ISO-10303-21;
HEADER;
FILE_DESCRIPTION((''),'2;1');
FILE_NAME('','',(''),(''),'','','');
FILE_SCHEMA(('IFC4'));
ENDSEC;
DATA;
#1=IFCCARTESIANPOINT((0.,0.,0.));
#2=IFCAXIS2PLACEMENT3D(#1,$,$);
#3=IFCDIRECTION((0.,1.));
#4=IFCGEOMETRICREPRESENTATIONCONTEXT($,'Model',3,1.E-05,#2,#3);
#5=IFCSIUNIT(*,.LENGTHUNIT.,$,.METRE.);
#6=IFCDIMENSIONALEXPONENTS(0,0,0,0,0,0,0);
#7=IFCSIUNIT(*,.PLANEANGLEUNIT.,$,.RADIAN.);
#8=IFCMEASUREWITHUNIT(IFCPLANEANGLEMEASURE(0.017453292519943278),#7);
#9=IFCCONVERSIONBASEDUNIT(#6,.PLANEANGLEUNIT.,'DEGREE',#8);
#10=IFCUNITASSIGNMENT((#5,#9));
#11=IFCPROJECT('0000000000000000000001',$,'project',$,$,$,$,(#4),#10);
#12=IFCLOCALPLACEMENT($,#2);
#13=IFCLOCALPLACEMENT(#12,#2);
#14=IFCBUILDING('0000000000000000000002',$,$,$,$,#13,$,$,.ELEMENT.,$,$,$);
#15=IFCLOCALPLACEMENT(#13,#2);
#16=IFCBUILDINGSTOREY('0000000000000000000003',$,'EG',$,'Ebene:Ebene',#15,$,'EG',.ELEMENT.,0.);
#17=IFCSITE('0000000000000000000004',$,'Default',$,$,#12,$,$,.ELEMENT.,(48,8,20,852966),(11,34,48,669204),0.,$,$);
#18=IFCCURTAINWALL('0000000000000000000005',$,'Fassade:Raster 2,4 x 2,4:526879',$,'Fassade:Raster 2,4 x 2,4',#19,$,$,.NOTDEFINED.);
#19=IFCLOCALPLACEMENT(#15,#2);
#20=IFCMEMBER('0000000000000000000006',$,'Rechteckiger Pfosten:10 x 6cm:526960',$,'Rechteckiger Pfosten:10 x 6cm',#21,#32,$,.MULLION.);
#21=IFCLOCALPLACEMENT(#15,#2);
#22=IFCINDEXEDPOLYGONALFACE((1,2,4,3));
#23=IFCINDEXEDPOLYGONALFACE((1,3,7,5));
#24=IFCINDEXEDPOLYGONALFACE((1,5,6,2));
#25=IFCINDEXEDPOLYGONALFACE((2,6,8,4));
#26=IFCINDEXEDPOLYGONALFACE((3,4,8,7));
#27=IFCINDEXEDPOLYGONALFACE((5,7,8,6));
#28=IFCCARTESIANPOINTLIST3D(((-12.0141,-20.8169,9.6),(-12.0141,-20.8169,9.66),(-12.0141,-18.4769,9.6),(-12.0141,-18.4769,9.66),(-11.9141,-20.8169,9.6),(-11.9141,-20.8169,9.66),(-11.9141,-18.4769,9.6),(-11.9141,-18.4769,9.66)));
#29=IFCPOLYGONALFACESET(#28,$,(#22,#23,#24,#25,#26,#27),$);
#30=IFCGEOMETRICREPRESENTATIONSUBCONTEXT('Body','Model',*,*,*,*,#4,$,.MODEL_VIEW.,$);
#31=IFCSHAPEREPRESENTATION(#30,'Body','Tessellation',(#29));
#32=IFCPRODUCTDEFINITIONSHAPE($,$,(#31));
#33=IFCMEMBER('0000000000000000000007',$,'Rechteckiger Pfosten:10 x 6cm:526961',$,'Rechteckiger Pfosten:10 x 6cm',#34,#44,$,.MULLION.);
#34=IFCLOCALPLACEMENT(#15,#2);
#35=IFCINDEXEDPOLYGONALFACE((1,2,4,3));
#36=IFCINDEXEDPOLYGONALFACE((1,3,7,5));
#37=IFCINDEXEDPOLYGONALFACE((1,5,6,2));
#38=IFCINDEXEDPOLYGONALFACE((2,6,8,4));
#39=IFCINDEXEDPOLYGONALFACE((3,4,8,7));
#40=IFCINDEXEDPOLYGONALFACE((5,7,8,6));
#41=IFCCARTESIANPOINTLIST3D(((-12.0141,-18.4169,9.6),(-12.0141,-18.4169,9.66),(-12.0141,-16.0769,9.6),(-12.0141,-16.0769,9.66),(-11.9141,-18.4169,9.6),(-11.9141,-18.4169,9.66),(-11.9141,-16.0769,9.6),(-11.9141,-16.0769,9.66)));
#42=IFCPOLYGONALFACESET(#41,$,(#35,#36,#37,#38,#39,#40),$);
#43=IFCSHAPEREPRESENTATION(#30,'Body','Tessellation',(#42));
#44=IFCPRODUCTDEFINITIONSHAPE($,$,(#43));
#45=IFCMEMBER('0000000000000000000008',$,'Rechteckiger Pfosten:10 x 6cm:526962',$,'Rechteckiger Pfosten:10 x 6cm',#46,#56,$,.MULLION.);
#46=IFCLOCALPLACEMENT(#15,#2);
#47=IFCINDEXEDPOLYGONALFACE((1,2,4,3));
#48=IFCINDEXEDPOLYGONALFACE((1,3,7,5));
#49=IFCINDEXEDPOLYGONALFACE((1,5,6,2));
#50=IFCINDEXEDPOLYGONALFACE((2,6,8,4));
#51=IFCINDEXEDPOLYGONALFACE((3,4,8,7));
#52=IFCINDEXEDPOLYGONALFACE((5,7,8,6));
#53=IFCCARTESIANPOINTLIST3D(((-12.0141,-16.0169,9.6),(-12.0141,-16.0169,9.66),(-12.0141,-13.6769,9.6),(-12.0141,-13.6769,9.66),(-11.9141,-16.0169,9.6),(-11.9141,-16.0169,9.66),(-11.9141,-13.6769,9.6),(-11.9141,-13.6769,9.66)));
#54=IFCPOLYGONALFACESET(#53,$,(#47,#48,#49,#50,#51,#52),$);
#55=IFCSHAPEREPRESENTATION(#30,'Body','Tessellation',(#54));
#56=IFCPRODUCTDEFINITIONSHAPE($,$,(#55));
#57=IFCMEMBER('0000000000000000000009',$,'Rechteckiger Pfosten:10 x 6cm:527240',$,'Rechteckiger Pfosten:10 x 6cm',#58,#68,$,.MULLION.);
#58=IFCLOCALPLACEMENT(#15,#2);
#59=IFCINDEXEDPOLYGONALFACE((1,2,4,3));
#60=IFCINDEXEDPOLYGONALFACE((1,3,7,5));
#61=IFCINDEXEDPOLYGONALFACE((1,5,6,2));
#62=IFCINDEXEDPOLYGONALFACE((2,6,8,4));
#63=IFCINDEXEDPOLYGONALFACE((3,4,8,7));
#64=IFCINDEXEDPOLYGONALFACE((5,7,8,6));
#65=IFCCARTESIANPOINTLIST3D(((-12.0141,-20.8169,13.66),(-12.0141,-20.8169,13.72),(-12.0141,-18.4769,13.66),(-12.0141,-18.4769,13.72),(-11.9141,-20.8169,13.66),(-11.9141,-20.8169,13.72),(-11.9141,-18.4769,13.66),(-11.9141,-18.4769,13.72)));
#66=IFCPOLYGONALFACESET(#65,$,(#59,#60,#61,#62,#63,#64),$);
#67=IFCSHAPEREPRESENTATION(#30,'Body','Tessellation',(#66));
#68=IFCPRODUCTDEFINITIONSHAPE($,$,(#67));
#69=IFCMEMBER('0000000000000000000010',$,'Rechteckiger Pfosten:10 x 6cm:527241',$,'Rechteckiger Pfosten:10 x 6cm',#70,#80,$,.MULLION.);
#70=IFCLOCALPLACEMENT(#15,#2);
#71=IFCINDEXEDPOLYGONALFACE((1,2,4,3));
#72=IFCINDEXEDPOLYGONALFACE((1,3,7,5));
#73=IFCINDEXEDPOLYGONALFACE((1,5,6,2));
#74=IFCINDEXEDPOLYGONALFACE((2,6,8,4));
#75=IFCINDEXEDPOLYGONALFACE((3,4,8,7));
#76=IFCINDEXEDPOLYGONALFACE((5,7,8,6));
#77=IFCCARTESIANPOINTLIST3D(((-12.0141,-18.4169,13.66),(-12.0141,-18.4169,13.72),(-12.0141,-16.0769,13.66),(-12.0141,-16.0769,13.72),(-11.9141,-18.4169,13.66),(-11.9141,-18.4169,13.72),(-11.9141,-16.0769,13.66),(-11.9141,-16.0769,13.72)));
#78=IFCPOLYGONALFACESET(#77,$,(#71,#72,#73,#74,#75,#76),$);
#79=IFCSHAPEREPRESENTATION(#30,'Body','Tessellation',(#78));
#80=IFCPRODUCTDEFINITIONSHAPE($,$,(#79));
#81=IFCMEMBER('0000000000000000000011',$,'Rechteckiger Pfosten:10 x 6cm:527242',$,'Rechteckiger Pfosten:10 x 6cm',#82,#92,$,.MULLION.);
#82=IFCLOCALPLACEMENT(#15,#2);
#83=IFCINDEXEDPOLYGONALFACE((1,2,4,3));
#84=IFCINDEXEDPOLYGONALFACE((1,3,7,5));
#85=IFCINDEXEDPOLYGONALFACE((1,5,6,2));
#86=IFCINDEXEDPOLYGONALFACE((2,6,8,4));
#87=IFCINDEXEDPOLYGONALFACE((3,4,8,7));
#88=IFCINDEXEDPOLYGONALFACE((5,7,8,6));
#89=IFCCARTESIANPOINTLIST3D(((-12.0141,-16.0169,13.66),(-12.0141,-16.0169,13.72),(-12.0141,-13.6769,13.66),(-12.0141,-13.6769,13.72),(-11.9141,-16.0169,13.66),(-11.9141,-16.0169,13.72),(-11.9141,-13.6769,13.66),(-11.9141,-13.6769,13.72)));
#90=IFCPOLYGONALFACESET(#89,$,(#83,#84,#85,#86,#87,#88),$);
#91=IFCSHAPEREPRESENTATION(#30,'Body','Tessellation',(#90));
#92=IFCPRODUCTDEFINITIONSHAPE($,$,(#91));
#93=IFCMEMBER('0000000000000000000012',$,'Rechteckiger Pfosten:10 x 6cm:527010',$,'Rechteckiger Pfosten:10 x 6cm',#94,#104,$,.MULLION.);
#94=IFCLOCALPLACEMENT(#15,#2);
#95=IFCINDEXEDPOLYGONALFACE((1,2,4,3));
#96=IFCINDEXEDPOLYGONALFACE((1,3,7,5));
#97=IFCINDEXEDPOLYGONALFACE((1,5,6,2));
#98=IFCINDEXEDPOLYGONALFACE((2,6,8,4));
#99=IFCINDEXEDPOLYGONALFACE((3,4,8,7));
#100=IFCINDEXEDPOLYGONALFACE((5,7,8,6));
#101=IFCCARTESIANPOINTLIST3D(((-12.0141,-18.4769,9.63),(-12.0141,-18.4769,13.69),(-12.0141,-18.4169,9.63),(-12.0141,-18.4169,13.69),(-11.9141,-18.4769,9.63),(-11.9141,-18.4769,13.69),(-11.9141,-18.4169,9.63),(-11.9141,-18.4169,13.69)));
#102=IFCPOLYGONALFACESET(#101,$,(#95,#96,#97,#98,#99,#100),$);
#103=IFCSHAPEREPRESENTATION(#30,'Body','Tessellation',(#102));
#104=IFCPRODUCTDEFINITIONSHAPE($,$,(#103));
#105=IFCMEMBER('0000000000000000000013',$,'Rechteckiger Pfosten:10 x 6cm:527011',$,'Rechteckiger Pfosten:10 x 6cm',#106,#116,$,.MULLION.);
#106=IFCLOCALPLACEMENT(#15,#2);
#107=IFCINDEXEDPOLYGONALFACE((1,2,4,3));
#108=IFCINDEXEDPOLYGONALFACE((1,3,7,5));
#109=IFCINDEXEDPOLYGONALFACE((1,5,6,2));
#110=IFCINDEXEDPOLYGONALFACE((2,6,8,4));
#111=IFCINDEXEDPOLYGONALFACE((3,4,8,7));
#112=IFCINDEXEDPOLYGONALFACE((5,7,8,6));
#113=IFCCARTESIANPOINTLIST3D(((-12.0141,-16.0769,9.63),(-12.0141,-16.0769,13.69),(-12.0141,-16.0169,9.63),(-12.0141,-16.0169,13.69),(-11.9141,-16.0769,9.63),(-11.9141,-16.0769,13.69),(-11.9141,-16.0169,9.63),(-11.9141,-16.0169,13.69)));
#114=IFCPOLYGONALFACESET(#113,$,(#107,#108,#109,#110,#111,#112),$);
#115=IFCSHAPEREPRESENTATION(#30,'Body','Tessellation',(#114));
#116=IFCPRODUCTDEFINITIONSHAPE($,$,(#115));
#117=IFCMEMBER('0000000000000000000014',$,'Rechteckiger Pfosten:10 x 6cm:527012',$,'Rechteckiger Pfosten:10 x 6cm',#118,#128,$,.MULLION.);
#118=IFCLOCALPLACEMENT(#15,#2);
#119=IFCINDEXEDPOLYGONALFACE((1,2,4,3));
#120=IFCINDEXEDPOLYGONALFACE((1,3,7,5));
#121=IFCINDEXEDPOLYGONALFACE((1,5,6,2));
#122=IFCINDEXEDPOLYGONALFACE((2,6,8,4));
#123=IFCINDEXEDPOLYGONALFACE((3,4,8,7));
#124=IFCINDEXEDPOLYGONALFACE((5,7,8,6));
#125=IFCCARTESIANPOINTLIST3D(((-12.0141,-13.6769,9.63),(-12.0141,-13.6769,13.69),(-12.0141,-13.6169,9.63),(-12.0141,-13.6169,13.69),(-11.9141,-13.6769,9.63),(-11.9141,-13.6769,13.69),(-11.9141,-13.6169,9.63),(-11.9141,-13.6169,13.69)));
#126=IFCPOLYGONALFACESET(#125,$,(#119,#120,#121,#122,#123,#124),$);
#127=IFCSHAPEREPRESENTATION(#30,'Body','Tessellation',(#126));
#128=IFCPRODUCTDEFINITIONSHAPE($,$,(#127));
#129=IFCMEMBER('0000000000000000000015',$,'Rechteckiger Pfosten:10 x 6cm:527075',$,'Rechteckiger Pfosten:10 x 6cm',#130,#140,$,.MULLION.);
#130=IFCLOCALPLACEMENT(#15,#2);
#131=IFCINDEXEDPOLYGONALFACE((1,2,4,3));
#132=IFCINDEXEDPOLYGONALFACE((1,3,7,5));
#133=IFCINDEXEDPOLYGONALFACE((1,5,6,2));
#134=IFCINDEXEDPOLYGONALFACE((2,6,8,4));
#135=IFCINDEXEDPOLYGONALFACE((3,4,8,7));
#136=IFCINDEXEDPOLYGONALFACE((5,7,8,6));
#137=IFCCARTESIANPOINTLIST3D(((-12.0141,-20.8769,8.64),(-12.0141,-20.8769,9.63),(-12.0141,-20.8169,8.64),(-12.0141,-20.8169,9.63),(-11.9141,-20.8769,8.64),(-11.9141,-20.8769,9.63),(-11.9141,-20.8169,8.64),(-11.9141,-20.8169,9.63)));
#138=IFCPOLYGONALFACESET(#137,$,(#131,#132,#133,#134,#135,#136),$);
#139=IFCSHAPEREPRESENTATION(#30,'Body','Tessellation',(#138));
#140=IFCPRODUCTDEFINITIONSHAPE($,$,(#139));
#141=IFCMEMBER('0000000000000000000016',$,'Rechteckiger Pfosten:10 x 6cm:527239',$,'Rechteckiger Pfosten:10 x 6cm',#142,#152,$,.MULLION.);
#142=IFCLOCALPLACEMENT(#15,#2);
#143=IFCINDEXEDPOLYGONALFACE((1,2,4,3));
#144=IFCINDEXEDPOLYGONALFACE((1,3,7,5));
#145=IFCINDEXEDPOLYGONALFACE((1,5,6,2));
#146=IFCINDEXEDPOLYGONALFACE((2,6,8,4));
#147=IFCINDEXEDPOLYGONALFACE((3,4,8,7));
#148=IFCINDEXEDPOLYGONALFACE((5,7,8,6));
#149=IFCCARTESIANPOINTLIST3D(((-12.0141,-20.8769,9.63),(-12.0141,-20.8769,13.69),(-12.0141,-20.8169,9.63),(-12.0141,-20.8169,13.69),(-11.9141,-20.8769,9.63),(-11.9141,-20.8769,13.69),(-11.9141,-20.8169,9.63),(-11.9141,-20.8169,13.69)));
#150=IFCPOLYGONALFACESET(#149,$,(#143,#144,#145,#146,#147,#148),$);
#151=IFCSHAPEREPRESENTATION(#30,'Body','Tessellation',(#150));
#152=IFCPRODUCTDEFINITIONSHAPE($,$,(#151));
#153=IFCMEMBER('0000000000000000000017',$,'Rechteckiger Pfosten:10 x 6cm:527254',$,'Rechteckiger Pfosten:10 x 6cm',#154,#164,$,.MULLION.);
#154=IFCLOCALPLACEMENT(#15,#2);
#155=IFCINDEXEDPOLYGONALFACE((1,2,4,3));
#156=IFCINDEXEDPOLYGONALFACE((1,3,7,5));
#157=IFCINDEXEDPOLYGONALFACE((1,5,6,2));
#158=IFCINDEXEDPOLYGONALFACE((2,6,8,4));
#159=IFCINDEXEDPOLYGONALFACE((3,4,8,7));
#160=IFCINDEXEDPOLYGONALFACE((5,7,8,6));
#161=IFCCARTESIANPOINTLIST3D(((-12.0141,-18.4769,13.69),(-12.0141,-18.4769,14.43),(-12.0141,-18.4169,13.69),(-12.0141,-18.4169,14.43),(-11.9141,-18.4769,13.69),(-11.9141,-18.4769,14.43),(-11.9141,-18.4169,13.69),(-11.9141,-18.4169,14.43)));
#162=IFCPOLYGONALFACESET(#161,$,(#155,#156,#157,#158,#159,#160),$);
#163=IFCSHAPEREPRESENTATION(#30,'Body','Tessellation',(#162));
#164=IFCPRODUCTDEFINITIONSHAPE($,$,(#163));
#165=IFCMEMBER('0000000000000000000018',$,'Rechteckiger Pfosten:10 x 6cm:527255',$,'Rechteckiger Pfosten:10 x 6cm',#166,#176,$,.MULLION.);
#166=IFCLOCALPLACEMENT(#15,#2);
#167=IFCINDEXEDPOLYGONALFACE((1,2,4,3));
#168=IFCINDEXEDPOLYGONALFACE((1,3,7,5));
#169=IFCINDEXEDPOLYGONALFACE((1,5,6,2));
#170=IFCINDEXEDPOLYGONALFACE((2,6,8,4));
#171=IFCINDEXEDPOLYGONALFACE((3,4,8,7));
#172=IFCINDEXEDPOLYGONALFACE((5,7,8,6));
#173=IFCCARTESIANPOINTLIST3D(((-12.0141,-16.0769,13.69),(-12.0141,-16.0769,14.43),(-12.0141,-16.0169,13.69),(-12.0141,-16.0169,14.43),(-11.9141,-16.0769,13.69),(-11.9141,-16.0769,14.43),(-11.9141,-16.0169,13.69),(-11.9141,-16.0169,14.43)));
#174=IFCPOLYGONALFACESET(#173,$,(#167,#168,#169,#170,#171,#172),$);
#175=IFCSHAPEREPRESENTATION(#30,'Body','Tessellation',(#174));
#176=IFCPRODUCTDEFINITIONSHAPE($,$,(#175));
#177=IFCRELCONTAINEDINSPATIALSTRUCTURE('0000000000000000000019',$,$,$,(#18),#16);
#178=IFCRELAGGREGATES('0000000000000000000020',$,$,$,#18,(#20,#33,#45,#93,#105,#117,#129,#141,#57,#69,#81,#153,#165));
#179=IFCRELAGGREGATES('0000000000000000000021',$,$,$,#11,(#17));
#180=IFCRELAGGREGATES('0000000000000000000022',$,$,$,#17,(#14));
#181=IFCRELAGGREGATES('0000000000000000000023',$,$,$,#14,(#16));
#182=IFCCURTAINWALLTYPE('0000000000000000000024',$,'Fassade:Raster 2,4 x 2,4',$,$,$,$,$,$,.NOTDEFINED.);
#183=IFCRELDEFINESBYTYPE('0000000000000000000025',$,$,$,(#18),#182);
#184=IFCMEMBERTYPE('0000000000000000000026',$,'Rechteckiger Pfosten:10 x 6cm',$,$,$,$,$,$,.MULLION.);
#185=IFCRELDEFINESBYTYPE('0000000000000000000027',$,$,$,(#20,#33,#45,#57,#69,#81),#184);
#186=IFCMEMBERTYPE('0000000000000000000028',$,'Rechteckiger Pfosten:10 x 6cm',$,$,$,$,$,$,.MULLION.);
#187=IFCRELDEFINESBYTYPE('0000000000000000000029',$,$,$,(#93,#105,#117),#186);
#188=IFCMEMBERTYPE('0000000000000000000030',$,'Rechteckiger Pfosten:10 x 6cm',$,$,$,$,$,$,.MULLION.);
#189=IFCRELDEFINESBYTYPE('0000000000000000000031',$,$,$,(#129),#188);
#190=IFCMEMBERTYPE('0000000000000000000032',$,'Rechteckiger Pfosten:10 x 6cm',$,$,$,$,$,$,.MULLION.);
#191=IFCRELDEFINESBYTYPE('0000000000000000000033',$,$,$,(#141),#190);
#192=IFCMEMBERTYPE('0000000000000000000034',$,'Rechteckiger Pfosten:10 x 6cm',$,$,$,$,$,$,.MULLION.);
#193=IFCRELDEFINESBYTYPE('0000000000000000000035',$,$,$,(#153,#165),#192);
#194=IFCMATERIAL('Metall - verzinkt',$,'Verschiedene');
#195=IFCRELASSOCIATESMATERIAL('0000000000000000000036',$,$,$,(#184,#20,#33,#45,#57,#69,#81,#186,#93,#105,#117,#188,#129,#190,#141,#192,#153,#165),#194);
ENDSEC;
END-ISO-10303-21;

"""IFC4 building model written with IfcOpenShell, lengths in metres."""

from ifc_helpers import new_model, entity, si_unit, converted_unit, direction, frame, origin, place, context, subcontext, project, spatial, indexed_curve, outline, extrude, source, transform, mapped, material, type_object, type_shapes, element, aggregate, save


model = new_model("IFC4")

# Units and contexts
model_context = context("Model", 3, precision=1e-05, world=origin(), true_north=direction((0.0, 1.0)))
body_context = subcontext(model_context, "Body", "Model", "MODEL_VIEW")
ifc_project = project(units=[si_unit("LENGTHUNIT", "METRE"), converted_unit("PLANEANGLEUNIT", "DEGREE", entity("IfcPlaneAngleMeasure", 0.017453292519943278), si_unit("PLANEANGLEUNIT", "RADIAN"), dimensions=[0, 0, 0, 0, 0, 0, 0])], contexts=[model_context])

# Site, building, storey
site_placement = place(None, origin())
site = spatial("IfcSite", under=ifc_project, at=site_placement, Name="Default", CompositionType="ELEMENT", RefLatitude=(48, 8, 20, 852966), RefLongitude=(11, 34, 48, 669204), RefElevation=0.0)
building_placement = place(site_placement, origin())
building = spatial("IfcBuilding", under=site, at=building_placement, CompositionType="ELEMENT")
storey_placement = place(building_placement, origin())
storey = spatial("IfcBuildingStorey", under=building, at=storey_placement, Name="EG", ObjectType="Ebene:Ebene", LongName="EG", CompositionType="ELEMENT", Elevation=0.0)

# Curtain wall, members
curtain_wall_type = type_object("IfcCurtainWallType", Name="Fassade:Raster 2,4 x 2,4", PredefinedType="NOTDEFINED")
curtain_wall_placement = place(storey_placement, origin())
curtain_wall = element("IfcCurtainWall", 1, at=curtain_wall_placement, inside=storey, type_object=curtain_wall_type, Name="Fassade:Raster 2,4 x 2,4:526879", ObjectType="Fassade:Raster 2,4 x 2,4", PredefinedType="NOTDEFINED")
ifc_material_1 = material(Name="Metall - verzinkt", Category="Verschiedene")
member_type_1 = type_object("IfcMemberType", Name="Rechteckiger Pfosten:10 x 6cm", PredefinedType="MULLION", material=ifc_material_1)
shared_shape_1 = source(origin(), body_context, "Body", "SweptSolid", [
    extrude(outline(indexed_curve([(-0.03, -0.05), (0.03, -0.05), (0.03, 0.05), (-0.03, 0.05), (-0.03, -0.05)], self_intersect=False)), frame((0.0, 0.0, -2.34), z_axis=(0.0, 0.0, 1.0), x_axis=(-1.0, 0.0, 0.0)), (0.0, 0.0, 1.0), 2.34),
])
type_shapes(member_type_1, [shared_shape_1])
member_1_placement = place(curtain_wall_placement, frame((-11.9641, -18.4769, 9.63), z_axis=(0.0, 1.0, 0.0), x_axis=(0.0, 0.0, 1.0)))
member_1 = element("IfcMember", 2, at=member_1_placement, type_object=member_type_1, material=ifc_material_1, Name="Rechteckiger Pfosten:10 x 6cm:526960", ObjectType="Rechteckiger Pfosten:10 x 6cm", PredefinedType="MULLION", context=body_context, shape_type="MappedRepresentation", body=[
    mapped(shared_shape_1, transform((0.0, 0.0, 0.0), scale=1.0)),
])
member_2_placement = place(curtain_wall_placement, frame((-11.9641, -16.0769, 9.63), z_axis=(0.0, 1.0, 0.0), x_axis=(0.0, 0.0, 1.0)))
member_2 = element("IfcMember", 3, at=member_2_placement, type_object=member_type_1, material=ifc_material_1, Name="Rechteckiger Pfosten:10 x 6cm:526961", ObjectType="Rechteckiger Pfosten:10 x 6cm", PredefinedType="MULLION", context=body_context, shape_type="MappedRepresentation", body=[
    mapped(shared_shape_1, transform((0.0, 0.0, 0.0), scale=1.0)),
])
member_3_placement = place(curtain_wall_placement, frame((-11.9641, -13.6769, 9.63), z_axis=(0.0, 1.0, 0.0), x_axis=(0.0, 0.0, 1.0)))
member_3 = element("IfcMember", 4, at=member_3_placement, type_object=member_type_1, material=ifc_material_1, Name="Rechteckiger Pfosten:10 x 6cm:526962", ObjectType="Rechteckiger Pfosten:10 x 6cm", PredefinedType="MULLION", context=body_context, shape_type="MappedRepresentation", body=[
    mapped(shared_shape_1, transform((0.0, 0.0, 0.0), scale=1.0)),
])
member_4_placement = place(curtain_wall_placement, frame((-11.9641, -18.4769, 13.69), z_axis=(0.0, 1.0, 0.0), x_axis=(0.0, 0.0, 1.0)))
member_4 = element("IfcMember", 5, at=member_4_placement, type_object=member_type_1, material=ifc_material_1, Name="Rechteckiger Pfosten:10 x 6cm:527240", ObjectType="Rechteckiger Pfosten:10 x 6cm", PredefinedType="MULLION", context=body_context, shape_type="MappedRepresentation", body=[
    mapped(shared_shape_1, transform((0.0, 0.0, 0.0), scale=1.0)),
])
member_5_placement = place(curtain_wall_placement, frame((-11.9641, -16.0769, 13.69), z_axis=(0.0, 1.0, 0.0), x_axis=(0.0, 0.0, 1.0)))
member_5 = element("IfcMember", 6, at=member_5_placement, type_object=member_type_1, material=ifc_material_1, Name="Rechteckiger Pfosten:10 x 6cm:527241", ObjectType="Rechteckiger Pfosten:10 x 6cm", PredefinedType="MULLION", context=body_context, shape_type="MappedRepresentation", body=[
    mapped(shared_shape_1, transform((0.0, 0.0, 0.0), scale=1.0)),
])
member_6_placement = place(curtain_wall_placement, frame((-11.9641, -13.6769, 13.69), z_axis=(0.0, 1.0, 0.0), x_axis=(0.0, 0.0, 1.0)))
member_6 = element("IfcMember", 7, at=member_6_placement, type_object=member_type_1, material=ifc_material_1, Name="Rechteckiger Pfosten:10 x 6cm:527242", ObjectType="Rechteckiger Pfosten:10 x 6cm", PredefinedType="MULLION", context=body_context, shape_type="MappedRepresentation", body=[
    mapped(shared_shape_1, transform((0.0, 0.0, 0.0), scale=1.0)),
])
member_type_2 = type_object("IfcMemberType", Name="Rechteckiger Pfosten:10 x 6cm", PredefinedType="MULLION", material=ifc_material_1)
shared_shape_2 = source(origin(), body_context, "Body", "SweptSolid", [
    extrude(outline(indexed_curve([(-0.03, -0.05), (0.03, -0.05), (0.03, 0.05), (-0.03, 0.05), (-0.03, -0.05)], self_intersect=False)), frame((0.0, 0.0, -4.06), z_axis=(0.0, 0.0, 1.0), x_axis=(-1.0, 0.0, 0.0)), (0.0, 0.0, 1.0), 4.06),
])
type_shapes(member_type_2, [shared_shape_2])
member_7_placement = place(curtain_wall_placement, frame((-11.9641, -18.4469, 9.63), z_axis=(0.0, 0.0, -1.0), x_axis=(0.0, 1.0, 0.0)))
member_7 = element("IfcMember", 8, at=member_7_placement, type_object=member_type_2, material=ifc_material_1, Name="Rechteckiger Pfosten:10 x 6cm:527010", ObjectType="Rechteckiger Pfosten:10 x 6cm", PredefinedType="MULLION", context=body_context, shape_type="MappedRepresentation", body=[
    mapped(shared_shape_2, transform((0.0, 0.0, 0.0), scale=1.0)),
])
member_8_placement = place(curtain_wall_placement, frame((-11.9641, -16.0469, 9.63), z_axis=(0.0, 0.0, -1.0), x_axis=(0.0, 1.0, 0.0)))
member_8 = element("IfcMember", 9, at=member_8_placement, type_object=member_type_2, material=ifc_material_1, Name="Rechteckiger Pfosten:10 x 6cm:527011", ObjectType="Rechteckiger Pfosten:10 x 6cm", PredefinedType="MULLION", context=body_context, shape_type="MappedRepresentation", body=[
    mapped(shared_shape_2, transform((0.0, 0.0, 0.0), scale=1.0)),
])
member_9_placement = place(curtain_wall_placement, frame((-11.9641, -13.6469, 9.63), z_axis=(0.0, 0.0, -1.0), x_axis=(0.0, 1.0, 0.0)))
member_9 = element("IfcMember", 10, at=member_9_placement, type_object=member_type_2, material=ifc_material_1, Name="Rechteckiger Pfosten:10 x 6cm:527012", ObjectType="Rechteckiger Pfosten:10 x 6cm", PredefinedType="MULLION", context=body_context, shape_type="MappedRepresentation", body=[
    mapped(shared_shape_2, transform((0.0, 0.0, 0.0), scale=1.0)),
])
member_type_3 = type_object("IfcMemberType", Name="Rechteckiger Pfosten:10 x 6cm", PredefinedType="MULLION", material=ifc_material_1)
shared_shape_3 = source(origin(), body_context, "Body", "SweptSolid", [
    extrude(outline(indexed_curve([(-0.03, -0.05), (0.03, -0.05), (0.03, 0.05), (-0.03, 0.05), (-0.03, -0.05)], self_intersect=False)), frame((-0.03, 0.0, -0.99), z_axis=(0.0, 0.0, 1.0), x_axis=(-1.0, 0.0, 0.0)), (0.0, 0.0, 1.0), 0.99),
])
type_shapes(member_type_3, [shared_shape_3])
member_10_placement = place(curtain_wall_placement, frame((-11.9641, -20.8769, 9.63), z_axis=(0.0, 0.0, 1.0), x_axis=(0.0, -1.0, 0.0)))
member_10 = element("IfcMember", 11, at=member_10_placement, type_object=member_type_3, material=ifc_material_1, Name="Rechteckiger Pfosten:10 x 6cm:527075", ObjectType="Rechteckiger Pfosten:10 x 6cm", PredefinedType="MULLION", context=body_context, shape_type="MappedRepresentation", body=[
    mapped(shared_shape_3, transform((0.0, 0.0, 0.0), scale=1.0)),
])
member_type_4 = type_object("IfcMemberType", Name="Rechteckiger Pfosten:10 x 6cm", PredefinedType="MULLION", material=ifc_material_1)
shared_shape_4 = source(origin(), body_context, "Body", "SweptSolid", [
    extrude(outline(indexed_curve([(-0.03, -0.05), (0.03, -0.05), (0.03, 0.05), (-0.03, 0.05), (-0.03, -0.05)], self_intersect=False)), frame((-0.03, 0.0, -4.06), z_axis=(0.0, 0.0, 1.0), x_axis=(-1.0, 0.0, 0.0)), (0.0, 0.0, 1.0), 4.06),
])
type_shapes(member_type_4, [shared_shape_4])
member_11_placement = place(curtain_wall_placement, frame((-11.9641, -20.8769, 13.69), z_axis=(0.0, 0.0, 1.0), x_axis=(0.0, -1.0, 0.0)))
member_11 = element("IfcMember", 12, at=member_11_placement, type_object=member_type_4, material=ifc_material_1, Name="Rechteckiger Pfosten:10 x 6cm:527239", ObjectType="Rechteckiger Pfosten:10 x 6cm", PredefinedType="MULLION", context=body_context, shape_type="MappedRepresentation", body=[
    mapped(shared_shape_4, transform((0.0, 0.0, 0.0), scale=1.0)),
])
member_type_5 = type_object("IfcMemberType", Name="Rechteckiger Pfosten:10 x 6cm", PredefinedType="MULLION", material=ifc_material_1)
shared_shape_5 = source(origin(), body_context, "Body", "SweptSolid", [
    extrude(outline(indexed_curve([(-0.03, -0.05), (0.03, -0.05), (0.03, 0.05), (-0.03, 0.05), (-0.03, -0.05)], self_intersect=False)), frame((0.0, 0.0, -0.74), z_axis=(0.0, 0.0, 1.0), x_axis=(-1.0, 0.0, 0.0)), (0.0, 0.0, 1.0), 0.74),
])
type_shapes(member_type_5, [shared_shape_5])
member_12_placement = place(curtain_wall_placement, frame((-11.9641, -18.4469, 13.69), z_axis=(0.0, 0.0, -1.0), x_axis=(0.0, 1.0, 0.0)))
member_12 = element("IfcMember", 13, at=member_12_placement, type_object=member_type_5, material=ifc_material_1, Name="Rechteckiger Pfosten:10 x 6cm:527254", ObjectType="Rechteckiger Pfosten:10 x 6cm", PredefinedType="MULLION", context=body_context, shape_type="MappedRepresentation", body=[
    mapped(shared_shape_5, transform((0.0, 0.0, 0.0), scale=1.0)),
])
member_13_placement = place(curtain_wall_placement, frame((-11.9641, -16.0469, 13.69), z_axis=(0.0, 0.0, -1.0), x_axis=(0.0, 1.0, 0.0)))
member_13 = element("IfcMember", 14, at=member_13_placement, type_object=member_type_5, material=ifc_material_1, Name="Rechteckiger Pfosten:10 x 6cm:527255", ObjectType="Rechteckiger Pfosten:10 x 6cm", PredefinedType="MULLION", context=body_context, shape_type="MappedRepresentation", body=[
    mapped(shared_shape_5, transform((0.0, 0.0, 0.0), scale=1.0)),
])
aggregate(curtain_wall, [member_1, member_2, member_3, member_7, member_8, member_9, member_10, member_11, member_4, member_5, member_6, member_12, member_13])

save(model, "model.ifc")
